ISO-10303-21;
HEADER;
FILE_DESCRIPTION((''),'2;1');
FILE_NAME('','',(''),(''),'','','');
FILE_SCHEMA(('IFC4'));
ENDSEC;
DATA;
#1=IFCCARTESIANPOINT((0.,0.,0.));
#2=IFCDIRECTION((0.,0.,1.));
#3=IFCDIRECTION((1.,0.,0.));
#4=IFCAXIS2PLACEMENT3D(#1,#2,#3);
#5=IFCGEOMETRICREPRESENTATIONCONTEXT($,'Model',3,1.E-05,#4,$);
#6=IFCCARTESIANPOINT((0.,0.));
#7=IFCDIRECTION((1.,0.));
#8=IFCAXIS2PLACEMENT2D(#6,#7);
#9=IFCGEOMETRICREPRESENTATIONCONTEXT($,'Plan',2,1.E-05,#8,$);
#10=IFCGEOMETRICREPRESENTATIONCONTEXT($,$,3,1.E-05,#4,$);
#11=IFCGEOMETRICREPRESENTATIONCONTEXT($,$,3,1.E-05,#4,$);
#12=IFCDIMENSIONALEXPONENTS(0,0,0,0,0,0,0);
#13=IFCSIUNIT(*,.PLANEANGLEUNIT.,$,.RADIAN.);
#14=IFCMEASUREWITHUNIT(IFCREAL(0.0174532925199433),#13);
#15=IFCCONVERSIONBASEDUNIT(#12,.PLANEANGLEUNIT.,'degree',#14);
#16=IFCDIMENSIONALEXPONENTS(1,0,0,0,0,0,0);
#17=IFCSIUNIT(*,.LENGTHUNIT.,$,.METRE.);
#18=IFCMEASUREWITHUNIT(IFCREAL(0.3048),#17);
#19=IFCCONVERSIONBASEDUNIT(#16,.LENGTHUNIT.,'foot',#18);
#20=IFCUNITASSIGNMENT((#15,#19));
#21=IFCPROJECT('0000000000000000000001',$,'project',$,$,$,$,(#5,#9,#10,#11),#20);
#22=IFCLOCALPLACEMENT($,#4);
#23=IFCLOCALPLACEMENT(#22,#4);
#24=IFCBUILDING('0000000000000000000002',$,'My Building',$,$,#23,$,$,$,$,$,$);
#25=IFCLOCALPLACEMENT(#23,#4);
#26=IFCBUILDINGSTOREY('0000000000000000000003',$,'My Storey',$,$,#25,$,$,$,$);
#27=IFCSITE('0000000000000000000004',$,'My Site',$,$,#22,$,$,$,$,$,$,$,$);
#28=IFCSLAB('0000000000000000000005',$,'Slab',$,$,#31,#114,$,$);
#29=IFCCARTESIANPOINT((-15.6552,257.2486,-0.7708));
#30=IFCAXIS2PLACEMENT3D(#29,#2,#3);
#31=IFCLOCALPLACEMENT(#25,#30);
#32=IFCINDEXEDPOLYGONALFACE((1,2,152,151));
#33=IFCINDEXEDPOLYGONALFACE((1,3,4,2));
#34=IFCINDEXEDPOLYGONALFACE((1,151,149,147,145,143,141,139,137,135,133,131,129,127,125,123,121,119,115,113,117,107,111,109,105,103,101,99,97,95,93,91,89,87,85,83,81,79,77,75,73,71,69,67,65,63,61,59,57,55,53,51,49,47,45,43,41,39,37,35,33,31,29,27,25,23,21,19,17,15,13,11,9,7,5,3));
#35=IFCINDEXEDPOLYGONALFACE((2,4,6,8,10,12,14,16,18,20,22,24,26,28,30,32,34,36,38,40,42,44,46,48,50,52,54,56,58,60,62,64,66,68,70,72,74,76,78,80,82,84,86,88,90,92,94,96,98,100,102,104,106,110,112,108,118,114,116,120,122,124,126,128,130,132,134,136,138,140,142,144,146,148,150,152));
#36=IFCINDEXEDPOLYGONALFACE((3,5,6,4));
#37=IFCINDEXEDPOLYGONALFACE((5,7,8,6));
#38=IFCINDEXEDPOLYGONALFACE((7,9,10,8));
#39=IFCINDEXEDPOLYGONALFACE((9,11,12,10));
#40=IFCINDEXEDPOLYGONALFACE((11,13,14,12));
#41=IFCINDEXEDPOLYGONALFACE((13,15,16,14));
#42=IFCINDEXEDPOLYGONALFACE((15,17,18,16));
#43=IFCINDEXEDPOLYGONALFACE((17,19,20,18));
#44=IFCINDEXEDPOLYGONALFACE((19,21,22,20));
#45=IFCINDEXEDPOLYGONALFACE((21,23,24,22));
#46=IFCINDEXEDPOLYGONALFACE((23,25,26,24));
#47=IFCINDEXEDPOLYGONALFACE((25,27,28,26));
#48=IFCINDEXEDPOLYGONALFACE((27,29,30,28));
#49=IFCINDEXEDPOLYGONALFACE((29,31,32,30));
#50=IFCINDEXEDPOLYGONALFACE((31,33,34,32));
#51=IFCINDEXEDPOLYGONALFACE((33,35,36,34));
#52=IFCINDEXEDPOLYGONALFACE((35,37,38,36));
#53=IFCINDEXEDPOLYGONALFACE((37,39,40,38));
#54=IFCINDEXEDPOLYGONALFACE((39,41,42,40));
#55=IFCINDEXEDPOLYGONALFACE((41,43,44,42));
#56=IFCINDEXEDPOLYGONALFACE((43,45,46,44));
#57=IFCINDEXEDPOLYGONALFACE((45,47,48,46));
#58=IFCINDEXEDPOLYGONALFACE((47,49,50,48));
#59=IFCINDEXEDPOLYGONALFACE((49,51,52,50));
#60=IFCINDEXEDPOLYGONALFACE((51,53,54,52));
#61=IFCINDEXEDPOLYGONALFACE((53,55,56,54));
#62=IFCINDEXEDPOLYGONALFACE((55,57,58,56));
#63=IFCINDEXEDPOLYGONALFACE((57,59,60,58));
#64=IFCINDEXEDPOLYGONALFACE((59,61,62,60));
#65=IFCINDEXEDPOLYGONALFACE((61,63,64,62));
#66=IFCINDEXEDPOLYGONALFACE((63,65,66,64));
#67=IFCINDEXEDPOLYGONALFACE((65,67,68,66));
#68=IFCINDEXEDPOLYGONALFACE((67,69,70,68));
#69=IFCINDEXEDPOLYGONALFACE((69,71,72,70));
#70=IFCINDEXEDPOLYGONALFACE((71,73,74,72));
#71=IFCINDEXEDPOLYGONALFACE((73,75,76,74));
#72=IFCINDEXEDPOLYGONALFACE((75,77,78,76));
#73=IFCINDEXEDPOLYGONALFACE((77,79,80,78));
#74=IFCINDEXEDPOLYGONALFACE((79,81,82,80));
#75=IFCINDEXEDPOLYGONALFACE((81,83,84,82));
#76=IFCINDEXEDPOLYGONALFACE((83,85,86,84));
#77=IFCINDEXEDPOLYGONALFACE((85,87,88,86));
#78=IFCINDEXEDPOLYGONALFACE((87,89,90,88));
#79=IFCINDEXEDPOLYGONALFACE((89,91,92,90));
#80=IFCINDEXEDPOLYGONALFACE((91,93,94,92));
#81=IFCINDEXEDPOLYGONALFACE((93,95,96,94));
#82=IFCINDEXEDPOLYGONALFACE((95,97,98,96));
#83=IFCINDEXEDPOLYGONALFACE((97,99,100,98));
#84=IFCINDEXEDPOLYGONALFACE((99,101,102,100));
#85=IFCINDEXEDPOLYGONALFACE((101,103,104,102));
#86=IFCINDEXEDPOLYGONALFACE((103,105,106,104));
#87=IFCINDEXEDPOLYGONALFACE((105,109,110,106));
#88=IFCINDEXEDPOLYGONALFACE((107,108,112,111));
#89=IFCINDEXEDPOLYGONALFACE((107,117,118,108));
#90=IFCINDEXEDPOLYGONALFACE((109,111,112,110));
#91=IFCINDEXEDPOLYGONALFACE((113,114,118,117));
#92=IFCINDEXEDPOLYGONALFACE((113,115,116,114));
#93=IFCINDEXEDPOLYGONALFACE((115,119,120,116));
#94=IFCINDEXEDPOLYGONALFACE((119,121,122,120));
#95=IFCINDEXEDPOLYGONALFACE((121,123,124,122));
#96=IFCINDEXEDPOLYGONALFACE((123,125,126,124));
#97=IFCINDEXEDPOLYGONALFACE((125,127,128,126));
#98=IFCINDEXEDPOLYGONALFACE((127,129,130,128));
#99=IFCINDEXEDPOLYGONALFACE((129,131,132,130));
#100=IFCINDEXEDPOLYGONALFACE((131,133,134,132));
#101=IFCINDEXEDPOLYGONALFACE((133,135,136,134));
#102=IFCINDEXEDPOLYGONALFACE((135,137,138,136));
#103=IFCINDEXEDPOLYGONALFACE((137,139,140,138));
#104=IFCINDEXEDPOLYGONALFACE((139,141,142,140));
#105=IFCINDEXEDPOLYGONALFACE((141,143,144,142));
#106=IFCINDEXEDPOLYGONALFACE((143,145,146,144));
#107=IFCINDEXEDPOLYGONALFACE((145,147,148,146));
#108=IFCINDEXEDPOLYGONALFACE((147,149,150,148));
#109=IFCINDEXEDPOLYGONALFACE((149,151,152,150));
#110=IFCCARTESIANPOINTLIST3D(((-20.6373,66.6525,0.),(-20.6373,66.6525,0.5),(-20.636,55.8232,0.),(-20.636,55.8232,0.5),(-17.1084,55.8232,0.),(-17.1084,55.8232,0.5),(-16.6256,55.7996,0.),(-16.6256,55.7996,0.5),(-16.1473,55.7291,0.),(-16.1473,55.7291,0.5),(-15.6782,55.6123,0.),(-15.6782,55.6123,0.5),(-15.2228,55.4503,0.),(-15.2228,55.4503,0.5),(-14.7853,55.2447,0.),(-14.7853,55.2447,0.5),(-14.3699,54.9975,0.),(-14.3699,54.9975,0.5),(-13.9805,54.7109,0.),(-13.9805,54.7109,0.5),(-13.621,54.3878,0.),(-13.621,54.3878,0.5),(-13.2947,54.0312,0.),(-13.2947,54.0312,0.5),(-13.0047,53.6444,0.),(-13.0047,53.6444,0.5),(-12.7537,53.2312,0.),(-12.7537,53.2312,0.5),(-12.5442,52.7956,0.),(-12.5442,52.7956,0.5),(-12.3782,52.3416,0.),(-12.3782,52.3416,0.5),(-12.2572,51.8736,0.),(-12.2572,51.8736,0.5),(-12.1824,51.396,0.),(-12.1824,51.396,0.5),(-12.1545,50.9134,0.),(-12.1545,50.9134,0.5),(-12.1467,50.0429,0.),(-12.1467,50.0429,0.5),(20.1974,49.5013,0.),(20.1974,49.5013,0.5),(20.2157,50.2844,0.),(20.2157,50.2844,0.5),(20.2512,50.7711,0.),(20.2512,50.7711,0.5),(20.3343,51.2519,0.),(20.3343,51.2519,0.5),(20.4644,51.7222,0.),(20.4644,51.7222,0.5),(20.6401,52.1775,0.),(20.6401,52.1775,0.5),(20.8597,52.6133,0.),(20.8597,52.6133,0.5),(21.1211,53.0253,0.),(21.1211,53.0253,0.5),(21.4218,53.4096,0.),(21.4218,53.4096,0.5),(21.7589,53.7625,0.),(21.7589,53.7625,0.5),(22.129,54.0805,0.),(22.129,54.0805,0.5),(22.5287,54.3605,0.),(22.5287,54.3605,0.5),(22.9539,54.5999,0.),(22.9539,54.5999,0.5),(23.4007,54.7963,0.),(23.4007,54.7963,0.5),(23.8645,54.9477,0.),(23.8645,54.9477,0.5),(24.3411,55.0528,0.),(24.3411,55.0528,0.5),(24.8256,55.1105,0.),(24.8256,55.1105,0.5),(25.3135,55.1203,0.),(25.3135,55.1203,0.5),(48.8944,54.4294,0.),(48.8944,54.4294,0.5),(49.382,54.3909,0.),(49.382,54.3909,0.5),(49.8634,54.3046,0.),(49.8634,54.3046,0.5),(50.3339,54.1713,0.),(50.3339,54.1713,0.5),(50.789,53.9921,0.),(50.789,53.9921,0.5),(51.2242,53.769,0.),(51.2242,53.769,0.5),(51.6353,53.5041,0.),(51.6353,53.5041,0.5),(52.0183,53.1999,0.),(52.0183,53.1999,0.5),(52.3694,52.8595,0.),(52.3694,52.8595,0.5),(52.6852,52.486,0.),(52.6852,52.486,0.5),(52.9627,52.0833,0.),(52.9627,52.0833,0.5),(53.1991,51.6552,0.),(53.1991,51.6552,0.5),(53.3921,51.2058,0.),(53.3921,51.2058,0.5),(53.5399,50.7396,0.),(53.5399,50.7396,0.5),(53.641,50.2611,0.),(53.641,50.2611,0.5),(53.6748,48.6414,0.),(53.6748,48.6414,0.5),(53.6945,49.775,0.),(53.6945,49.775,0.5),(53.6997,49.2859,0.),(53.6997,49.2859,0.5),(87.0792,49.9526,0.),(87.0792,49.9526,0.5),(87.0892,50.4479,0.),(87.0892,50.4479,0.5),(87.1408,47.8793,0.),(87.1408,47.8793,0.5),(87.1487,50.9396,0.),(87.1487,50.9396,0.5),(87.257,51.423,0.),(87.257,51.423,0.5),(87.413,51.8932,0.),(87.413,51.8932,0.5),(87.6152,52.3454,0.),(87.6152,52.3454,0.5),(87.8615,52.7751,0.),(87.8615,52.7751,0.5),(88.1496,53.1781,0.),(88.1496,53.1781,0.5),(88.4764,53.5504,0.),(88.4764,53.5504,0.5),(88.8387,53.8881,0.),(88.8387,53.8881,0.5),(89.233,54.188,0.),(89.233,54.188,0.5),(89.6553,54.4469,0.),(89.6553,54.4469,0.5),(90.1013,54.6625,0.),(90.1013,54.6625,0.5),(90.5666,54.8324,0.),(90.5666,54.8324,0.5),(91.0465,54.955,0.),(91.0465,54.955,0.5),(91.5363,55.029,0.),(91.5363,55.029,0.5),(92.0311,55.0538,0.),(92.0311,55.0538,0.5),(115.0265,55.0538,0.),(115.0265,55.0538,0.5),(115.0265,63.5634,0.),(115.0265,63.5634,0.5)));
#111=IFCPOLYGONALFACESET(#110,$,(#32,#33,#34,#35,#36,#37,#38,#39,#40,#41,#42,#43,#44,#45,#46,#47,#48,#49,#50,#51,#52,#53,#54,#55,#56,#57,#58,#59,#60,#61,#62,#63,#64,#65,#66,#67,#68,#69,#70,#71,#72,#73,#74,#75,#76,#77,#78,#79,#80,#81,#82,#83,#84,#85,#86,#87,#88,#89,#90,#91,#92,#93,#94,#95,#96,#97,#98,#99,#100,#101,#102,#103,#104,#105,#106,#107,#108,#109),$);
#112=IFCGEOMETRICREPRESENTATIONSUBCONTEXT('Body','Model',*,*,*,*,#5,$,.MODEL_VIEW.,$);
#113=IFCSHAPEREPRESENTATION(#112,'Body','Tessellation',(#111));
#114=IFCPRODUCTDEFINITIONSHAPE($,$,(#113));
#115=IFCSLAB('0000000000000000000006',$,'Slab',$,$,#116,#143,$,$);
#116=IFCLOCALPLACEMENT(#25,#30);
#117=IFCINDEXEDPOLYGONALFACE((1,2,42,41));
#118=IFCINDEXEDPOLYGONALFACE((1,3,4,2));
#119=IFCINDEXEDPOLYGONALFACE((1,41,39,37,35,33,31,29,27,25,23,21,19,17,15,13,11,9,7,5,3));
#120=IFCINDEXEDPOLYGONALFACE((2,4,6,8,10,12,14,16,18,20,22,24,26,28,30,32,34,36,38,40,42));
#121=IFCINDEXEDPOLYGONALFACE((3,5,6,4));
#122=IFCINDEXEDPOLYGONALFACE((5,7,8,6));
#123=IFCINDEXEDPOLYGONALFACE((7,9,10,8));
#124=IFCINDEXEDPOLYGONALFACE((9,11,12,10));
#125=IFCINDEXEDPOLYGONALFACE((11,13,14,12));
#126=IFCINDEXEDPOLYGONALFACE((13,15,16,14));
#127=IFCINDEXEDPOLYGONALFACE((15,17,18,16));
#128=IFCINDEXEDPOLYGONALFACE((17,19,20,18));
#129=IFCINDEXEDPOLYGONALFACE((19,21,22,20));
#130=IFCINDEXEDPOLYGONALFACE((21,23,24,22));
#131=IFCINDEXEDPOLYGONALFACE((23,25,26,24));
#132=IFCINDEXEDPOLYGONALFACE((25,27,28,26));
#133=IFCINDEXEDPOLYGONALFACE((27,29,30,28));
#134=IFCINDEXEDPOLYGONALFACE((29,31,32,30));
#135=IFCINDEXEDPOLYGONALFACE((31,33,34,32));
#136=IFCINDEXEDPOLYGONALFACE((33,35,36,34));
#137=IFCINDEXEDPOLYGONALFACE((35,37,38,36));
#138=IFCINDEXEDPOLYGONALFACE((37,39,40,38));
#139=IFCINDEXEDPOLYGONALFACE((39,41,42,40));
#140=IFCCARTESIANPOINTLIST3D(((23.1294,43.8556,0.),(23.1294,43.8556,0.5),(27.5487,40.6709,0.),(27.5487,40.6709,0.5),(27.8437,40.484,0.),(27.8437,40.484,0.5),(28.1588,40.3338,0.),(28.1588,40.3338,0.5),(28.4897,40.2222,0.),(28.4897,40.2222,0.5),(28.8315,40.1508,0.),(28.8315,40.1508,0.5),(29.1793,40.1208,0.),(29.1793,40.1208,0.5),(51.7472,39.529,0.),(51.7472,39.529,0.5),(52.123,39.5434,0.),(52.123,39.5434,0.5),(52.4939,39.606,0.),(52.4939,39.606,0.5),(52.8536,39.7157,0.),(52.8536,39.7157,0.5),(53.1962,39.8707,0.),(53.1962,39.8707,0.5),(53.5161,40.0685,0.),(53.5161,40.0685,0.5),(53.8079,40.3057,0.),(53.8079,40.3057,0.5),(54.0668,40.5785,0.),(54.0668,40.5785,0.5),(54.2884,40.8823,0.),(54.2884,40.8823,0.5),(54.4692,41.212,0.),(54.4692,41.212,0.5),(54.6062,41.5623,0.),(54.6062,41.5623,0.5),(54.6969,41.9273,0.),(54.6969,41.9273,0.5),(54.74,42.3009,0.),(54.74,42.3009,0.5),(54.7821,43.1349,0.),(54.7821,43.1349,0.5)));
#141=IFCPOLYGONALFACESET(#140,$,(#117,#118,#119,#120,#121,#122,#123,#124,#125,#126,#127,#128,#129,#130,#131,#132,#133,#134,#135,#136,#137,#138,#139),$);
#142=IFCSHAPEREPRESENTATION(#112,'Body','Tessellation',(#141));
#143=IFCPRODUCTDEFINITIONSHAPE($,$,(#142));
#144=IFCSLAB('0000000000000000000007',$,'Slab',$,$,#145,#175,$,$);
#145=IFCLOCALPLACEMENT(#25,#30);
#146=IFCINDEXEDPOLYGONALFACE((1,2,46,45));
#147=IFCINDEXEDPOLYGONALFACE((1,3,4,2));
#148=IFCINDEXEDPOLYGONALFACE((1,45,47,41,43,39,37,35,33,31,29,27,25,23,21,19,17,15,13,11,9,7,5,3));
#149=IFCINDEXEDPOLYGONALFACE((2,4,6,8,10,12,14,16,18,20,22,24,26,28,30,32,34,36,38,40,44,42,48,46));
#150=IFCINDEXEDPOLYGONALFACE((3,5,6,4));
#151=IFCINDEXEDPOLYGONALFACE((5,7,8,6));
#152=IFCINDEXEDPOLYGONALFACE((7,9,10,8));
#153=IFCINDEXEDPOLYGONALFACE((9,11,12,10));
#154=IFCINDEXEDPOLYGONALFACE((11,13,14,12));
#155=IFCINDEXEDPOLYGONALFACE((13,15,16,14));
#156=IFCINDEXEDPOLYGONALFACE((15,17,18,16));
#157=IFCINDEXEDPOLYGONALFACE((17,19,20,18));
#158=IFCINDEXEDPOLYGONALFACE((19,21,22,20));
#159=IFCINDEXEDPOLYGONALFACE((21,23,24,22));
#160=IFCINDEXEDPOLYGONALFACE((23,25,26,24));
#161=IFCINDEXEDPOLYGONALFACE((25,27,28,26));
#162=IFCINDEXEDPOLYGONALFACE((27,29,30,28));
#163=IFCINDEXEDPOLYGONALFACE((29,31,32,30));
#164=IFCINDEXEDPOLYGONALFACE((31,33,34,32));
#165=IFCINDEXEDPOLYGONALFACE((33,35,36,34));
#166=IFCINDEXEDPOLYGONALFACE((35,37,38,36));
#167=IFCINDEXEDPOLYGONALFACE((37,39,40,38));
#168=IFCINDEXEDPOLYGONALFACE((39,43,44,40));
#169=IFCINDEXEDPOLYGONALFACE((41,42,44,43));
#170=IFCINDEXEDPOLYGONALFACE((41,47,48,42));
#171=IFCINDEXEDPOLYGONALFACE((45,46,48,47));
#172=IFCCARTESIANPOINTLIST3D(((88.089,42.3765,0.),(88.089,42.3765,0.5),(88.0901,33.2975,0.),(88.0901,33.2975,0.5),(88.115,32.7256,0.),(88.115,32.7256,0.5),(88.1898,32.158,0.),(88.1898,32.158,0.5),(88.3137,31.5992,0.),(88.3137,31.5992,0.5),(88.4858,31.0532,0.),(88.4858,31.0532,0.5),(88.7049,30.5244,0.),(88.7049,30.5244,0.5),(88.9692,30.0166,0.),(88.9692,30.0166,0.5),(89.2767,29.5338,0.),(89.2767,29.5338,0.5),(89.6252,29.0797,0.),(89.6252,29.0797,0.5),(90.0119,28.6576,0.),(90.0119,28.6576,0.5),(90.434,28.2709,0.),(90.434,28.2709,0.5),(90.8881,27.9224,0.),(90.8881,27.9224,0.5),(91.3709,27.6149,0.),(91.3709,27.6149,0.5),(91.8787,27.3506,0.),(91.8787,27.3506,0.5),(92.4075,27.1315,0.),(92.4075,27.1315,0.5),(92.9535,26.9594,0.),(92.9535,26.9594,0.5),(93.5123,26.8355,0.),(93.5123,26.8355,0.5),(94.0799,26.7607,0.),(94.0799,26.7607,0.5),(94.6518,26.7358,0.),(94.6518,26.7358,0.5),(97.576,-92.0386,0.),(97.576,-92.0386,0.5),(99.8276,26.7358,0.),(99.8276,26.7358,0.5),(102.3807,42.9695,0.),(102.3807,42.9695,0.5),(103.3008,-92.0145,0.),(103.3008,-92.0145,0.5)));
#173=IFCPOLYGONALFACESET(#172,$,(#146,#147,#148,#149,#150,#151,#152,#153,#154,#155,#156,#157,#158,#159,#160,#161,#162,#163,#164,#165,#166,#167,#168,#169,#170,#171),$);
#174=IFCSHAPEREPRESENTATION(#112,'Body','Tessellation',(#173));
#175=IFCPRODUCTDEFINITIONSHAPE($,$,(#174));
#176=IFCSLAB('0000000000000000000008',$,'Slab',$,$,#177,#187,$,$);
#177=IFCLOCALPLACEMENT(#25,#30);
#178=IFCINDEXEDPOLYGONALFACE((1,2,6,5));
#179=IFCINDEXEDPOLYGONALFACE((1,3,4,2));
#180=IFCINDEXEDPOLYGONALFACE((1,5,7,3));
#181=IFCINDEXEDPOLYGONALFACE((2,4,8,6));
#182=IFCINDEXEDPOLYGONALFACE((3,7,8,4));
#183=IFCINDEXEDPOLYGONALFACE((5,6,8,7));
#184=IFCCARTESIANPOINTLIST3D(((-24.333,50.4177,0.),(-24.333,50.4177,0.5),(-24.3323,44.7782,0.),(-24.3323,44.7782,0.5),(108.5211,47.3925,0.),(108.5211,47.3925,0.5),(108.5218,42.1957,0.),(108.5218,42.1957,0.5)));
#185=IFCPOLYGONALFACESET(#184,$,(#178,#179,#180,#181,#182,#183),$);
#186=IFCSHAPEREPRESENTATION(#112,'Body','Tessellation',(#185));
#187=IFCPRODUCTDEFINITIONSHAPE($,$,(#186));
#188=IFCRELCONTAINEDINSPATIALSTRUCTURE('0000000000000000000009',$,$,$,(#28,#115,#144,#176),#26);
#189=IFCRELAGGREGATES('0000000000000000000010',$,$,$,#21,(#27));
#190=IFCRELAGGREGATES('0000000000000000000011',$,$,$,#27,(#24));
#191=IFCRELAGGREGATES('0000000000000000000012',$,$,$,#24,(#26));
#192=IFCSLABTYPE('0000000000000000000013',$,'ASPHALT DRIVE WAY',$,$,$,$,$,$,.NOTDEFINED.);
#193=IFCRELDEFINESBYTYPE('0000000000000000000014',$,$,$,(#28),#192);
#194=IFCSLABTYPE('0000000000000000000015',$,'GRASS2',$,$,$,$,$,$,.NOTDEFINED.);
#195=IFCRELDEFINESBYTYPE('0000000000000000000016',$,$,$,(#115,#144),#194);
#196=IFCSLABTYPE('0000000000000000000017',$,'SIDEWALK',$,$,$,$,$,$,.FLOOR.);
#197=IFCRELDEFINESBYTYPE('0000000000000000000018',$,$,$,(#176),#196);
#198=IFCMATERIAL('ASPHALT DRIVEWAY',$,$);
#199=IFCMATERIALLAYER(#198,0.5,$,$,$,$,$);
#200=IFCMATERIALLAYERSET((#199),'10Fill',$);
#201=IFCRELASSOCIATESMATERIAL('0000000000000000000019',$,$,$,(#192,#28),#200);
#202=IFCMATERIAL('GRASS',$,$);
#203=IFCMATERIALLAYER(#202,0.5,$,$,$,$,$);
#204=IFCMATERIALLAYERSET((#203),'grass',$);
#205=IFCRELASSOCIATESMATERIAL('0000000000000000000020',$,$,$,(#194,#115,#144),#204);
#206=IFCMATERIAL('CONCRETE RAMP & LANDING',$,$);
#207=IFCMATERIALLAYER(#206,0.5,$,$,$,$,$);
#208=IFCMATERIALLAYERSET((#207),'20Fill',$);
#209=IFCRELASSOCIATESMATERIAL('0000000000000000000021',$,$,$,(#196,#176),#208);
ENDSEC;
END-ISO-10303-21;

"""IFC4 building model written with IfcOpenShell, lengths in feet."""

from ifc_helpers import new_model, entity, si_unit, converted_unit, frame, origin_with_axes, origin_2d_with_axis, place, context, subcontext, project, spatial, line, arc, indexed_curve, outline, extrude, material, layer, layer_set, layer_usage, type_object, element, save


model = new_model("IFC4")

# Units and contexts
model_context = context("Model", 3, precision=1e-05, world=origin_with_axes())
plan_context = context("Plan", 2, precision=1e-05, world=origin_2d_with_axis())
context_of_model_1 = context(None, 3, precision=1e-05, world=origin_with_axes())
context_of_model_2 = context(None, 3, precision=1e-05, world=origin_with_axes())
body_context = subcontext(model_context, "Body", "Model", "MODEL_VIEW")
ifc_project = project(units=[converted_unit("PLANEANGLEUNIT", "degree", entity("IfcReal", 0.0174532925199433), si_unit("PLANEANGLEUNIT", "RADIAN"), dimensions=[0, 0, 0, 0, 0, 0, 0]), converted_unit("LENGTHUNIT", "foot", entity("IfcReal", 0.3048), si_unit("LENGTHUNIT", "METRE"), dimensions=[1, 0, 0, 0, 0, 0, 0])], contexts=[model_context, plan_context, context_of_model_1, context_of_model_2])

# Site, building, storey
site_placement = place(None, origin_with_axes())
site = spatial("IfcSite", under=ifc_project, at=site_placement, Name="My Site")
building_placement = place(site_placement, origin_with_axes())
building = spatial("IfcBuilding", under=site, at=building_placement, Name="My Building")
storey_placement = place(building_placement, origin_with_axes())
storey = spatial("IfcBuildingStorey", under=building, at=storey_placement, Name="My Storey")

# Slabs
ifc_material_1 = material(Name="ASPHALT DRIVEWAY")
ifc_layer_1 = layer(ifc_material_1, 0.5)
ifc_layer_set_1 = layer_set([ifc_layer_1], Name="10Fill")
slab_type_1 = type_object("IfcSlabType", Name="ASPHALT DRIVE WAY", PredefinedType="NOTDEFINED", material=ifc_layer_set_1)
ifc_layer_usage_1 = layer_usage(ifc_layer_set_1, "AXIS3", "POSITIVE", 0.0)
slab_1_placement = place(storey_placement, frame((-15.6552, 257.2486, -0.7708), z_axis=(0.0, 0.0, 1.0), x_axis=(1.0, 0.0, 0.0)))
element("IfcSlab", 1, at=slab_1_placement, inside=storey, type_object=slab_type_1, material=ifc_layer_usage_1, Name="Slab", context=body_context, shape_type="SweptSolid", body=[
    extrude(outline(indexed_curve([(115.0265, 63.5634), (-20.6373, 66.6525), (-20.636, 55.8232), (-12.1467, 50.0429), (20.1974, 49.5013), (53.6748, 48.6414), (87.1408, 47.8793), (115.0265, 55.0538), (-12.1545, 50.9134), (-17.1084, 55.8232), (-13.621, 54.3878), (25.3135, 55.1203), (20.2157, 50.2844), (21.7589, 53.7625), (53.6997, 49.2859), (48.8944, 54.4294), (52.3694, 52.8595), (87.0792, 49.9526), (92.0311, 55.0538), (88.4764, 53.5504)], segments=[arc(15, 17, 16), line(16, 12), arc(12, 14, 13), line(13, 5), line(5, 4), line(4, 9), arc(9, 11, 10), line(10, 3), line(3, 2), line(2, 1), line(1, 8), line(8, 19), arc(19, 20, 18), line(18, 7), line(7, 6), line(6, 15)], self_intersect=False)), None, (0.0, 0.0, 1.0), 0.5),
])
ifc_material_2 = material(Name="GRASS")
ifc_layer_2 = layer(ifc_material_2, 0.5)
ifc_layer_set_2 = layer_set([ifc_layer_2], Name="grass")
ifc_layer_usage_2 = layer_usage(ifc_layer_set_2, "AXIS3", "POSITIVE", 0.0)
slab_type_2 = type_object("IfcSlabType", Name="GRASS2", PredefinedType="NOTDEFINED", material=ifc_layer_set_2)
slab_2_placement = place(storey_placement, frame((-15.6552, 257.2486, -0.7708), z_axis=(0.0, 0.0, 1.0), x_axis=(1.0, 0.0, 0.0)))
element("IfcSlab", 2, at=slab_2_placement, inside=storey, type_object=slab_type_2, material=ifc_layer_usage_2, Name="Slab", context=body_context, shape_type="SweptSolid", body=[
    extrude(outline(indexed_curve([(23.1294, 43.8556), (54.7821, 43.1349), (54.74, 42.3009), (53.8079, 40.3057), (51.7472, 39.529), (29.1793, 40.1208), (28.3226, 40.273), (27.5487, 40.6709)], segments=[arc(8, 7, 6), line(6, 5), arc(5, 4, 3), line(3, 2), line(2, 1), line(1, 8)], self_intersect=False)), None, (0.0, 0.0, 1.0), 0.5),
])
ifc_layer_usage_3 = layer_usage(ifc_layer_set_2, "AXIS3", "POSITIVE", 0.0)
slab_3_placement = place(storey_placement, frame((-15.6552, 257.2486, -0.7708), z_axis=(0.0, 0.0, 1.0), x_axis=(1.0, 0.0, 0.0)))
element("IfcSlab", 3, at=slab_3_placement, inside=storey, type_object=slab_type_2, material=ifc_layer_usage_3, Name="Slab", context=body_context, shape_type="SweptSolid", body=[
    extrude(outline(indexed_curve([(88.089, 42.3765), (88.0901, 33.2975), (90.0119, 28.6576), (94.6518, 26.7358), (99.8276, 26.7358), (97.576, -92.0386), (103.3008, -92.0145), (102.3807, 42.9695)], segments=[line(1, 8), line(8, 7), line(7, 6), line(6, 5), line(5, 4), arc(4, 3, 2), line(2, 1)], self_intersect=False)), None, (0.0, 0.0, 1.0), 0.5),
])
ifc_material_3 = material(Name="CONCRETE RAMP & LANDING")
ifc_layer_3 = layer(ifc_material_3, 0.5)
ifc_layer_set_3 = layer_set([ifc_layer_3], Name="20Fill")
ifc_layer_usage_4 = layer_usage(ifc_layer_set_3, "AXIS3", "POSITIVE", 0.0)
slab_type_3 = type_object("IfcSlabType", Name="SIDEWALK", PredefinedType="FLOOR", material=ifc_layer_set_3)
slab_4_placement = place(storey_placement, frame((-15.6552, 257.2486, -0.7708), z_axis=(0.0, 0.0, 1.0), x_axis=(1.0, 0.0, 0.0)))
element("IfcSlab", 4, at=slab_4_placement, inside=storey, type_object=slab_type_3, material=ifc_layer_usage_4, Name="Slab", context=body_context, shape_type="SweptSolid", body=[
    extrude(outline(indexed_curve([(108.5218, 42.1957), (-24.3323, 44.7782), (-24.333, 50.4177), (108.5211, 47.3925)], segments=[line(3, 2), line(2, 1), line(1, 4), line(4, 3)], self_intersect=False)), None, (0.0, 0.0, 1.0), 0.5),
])

save(model, "model.ifc")
